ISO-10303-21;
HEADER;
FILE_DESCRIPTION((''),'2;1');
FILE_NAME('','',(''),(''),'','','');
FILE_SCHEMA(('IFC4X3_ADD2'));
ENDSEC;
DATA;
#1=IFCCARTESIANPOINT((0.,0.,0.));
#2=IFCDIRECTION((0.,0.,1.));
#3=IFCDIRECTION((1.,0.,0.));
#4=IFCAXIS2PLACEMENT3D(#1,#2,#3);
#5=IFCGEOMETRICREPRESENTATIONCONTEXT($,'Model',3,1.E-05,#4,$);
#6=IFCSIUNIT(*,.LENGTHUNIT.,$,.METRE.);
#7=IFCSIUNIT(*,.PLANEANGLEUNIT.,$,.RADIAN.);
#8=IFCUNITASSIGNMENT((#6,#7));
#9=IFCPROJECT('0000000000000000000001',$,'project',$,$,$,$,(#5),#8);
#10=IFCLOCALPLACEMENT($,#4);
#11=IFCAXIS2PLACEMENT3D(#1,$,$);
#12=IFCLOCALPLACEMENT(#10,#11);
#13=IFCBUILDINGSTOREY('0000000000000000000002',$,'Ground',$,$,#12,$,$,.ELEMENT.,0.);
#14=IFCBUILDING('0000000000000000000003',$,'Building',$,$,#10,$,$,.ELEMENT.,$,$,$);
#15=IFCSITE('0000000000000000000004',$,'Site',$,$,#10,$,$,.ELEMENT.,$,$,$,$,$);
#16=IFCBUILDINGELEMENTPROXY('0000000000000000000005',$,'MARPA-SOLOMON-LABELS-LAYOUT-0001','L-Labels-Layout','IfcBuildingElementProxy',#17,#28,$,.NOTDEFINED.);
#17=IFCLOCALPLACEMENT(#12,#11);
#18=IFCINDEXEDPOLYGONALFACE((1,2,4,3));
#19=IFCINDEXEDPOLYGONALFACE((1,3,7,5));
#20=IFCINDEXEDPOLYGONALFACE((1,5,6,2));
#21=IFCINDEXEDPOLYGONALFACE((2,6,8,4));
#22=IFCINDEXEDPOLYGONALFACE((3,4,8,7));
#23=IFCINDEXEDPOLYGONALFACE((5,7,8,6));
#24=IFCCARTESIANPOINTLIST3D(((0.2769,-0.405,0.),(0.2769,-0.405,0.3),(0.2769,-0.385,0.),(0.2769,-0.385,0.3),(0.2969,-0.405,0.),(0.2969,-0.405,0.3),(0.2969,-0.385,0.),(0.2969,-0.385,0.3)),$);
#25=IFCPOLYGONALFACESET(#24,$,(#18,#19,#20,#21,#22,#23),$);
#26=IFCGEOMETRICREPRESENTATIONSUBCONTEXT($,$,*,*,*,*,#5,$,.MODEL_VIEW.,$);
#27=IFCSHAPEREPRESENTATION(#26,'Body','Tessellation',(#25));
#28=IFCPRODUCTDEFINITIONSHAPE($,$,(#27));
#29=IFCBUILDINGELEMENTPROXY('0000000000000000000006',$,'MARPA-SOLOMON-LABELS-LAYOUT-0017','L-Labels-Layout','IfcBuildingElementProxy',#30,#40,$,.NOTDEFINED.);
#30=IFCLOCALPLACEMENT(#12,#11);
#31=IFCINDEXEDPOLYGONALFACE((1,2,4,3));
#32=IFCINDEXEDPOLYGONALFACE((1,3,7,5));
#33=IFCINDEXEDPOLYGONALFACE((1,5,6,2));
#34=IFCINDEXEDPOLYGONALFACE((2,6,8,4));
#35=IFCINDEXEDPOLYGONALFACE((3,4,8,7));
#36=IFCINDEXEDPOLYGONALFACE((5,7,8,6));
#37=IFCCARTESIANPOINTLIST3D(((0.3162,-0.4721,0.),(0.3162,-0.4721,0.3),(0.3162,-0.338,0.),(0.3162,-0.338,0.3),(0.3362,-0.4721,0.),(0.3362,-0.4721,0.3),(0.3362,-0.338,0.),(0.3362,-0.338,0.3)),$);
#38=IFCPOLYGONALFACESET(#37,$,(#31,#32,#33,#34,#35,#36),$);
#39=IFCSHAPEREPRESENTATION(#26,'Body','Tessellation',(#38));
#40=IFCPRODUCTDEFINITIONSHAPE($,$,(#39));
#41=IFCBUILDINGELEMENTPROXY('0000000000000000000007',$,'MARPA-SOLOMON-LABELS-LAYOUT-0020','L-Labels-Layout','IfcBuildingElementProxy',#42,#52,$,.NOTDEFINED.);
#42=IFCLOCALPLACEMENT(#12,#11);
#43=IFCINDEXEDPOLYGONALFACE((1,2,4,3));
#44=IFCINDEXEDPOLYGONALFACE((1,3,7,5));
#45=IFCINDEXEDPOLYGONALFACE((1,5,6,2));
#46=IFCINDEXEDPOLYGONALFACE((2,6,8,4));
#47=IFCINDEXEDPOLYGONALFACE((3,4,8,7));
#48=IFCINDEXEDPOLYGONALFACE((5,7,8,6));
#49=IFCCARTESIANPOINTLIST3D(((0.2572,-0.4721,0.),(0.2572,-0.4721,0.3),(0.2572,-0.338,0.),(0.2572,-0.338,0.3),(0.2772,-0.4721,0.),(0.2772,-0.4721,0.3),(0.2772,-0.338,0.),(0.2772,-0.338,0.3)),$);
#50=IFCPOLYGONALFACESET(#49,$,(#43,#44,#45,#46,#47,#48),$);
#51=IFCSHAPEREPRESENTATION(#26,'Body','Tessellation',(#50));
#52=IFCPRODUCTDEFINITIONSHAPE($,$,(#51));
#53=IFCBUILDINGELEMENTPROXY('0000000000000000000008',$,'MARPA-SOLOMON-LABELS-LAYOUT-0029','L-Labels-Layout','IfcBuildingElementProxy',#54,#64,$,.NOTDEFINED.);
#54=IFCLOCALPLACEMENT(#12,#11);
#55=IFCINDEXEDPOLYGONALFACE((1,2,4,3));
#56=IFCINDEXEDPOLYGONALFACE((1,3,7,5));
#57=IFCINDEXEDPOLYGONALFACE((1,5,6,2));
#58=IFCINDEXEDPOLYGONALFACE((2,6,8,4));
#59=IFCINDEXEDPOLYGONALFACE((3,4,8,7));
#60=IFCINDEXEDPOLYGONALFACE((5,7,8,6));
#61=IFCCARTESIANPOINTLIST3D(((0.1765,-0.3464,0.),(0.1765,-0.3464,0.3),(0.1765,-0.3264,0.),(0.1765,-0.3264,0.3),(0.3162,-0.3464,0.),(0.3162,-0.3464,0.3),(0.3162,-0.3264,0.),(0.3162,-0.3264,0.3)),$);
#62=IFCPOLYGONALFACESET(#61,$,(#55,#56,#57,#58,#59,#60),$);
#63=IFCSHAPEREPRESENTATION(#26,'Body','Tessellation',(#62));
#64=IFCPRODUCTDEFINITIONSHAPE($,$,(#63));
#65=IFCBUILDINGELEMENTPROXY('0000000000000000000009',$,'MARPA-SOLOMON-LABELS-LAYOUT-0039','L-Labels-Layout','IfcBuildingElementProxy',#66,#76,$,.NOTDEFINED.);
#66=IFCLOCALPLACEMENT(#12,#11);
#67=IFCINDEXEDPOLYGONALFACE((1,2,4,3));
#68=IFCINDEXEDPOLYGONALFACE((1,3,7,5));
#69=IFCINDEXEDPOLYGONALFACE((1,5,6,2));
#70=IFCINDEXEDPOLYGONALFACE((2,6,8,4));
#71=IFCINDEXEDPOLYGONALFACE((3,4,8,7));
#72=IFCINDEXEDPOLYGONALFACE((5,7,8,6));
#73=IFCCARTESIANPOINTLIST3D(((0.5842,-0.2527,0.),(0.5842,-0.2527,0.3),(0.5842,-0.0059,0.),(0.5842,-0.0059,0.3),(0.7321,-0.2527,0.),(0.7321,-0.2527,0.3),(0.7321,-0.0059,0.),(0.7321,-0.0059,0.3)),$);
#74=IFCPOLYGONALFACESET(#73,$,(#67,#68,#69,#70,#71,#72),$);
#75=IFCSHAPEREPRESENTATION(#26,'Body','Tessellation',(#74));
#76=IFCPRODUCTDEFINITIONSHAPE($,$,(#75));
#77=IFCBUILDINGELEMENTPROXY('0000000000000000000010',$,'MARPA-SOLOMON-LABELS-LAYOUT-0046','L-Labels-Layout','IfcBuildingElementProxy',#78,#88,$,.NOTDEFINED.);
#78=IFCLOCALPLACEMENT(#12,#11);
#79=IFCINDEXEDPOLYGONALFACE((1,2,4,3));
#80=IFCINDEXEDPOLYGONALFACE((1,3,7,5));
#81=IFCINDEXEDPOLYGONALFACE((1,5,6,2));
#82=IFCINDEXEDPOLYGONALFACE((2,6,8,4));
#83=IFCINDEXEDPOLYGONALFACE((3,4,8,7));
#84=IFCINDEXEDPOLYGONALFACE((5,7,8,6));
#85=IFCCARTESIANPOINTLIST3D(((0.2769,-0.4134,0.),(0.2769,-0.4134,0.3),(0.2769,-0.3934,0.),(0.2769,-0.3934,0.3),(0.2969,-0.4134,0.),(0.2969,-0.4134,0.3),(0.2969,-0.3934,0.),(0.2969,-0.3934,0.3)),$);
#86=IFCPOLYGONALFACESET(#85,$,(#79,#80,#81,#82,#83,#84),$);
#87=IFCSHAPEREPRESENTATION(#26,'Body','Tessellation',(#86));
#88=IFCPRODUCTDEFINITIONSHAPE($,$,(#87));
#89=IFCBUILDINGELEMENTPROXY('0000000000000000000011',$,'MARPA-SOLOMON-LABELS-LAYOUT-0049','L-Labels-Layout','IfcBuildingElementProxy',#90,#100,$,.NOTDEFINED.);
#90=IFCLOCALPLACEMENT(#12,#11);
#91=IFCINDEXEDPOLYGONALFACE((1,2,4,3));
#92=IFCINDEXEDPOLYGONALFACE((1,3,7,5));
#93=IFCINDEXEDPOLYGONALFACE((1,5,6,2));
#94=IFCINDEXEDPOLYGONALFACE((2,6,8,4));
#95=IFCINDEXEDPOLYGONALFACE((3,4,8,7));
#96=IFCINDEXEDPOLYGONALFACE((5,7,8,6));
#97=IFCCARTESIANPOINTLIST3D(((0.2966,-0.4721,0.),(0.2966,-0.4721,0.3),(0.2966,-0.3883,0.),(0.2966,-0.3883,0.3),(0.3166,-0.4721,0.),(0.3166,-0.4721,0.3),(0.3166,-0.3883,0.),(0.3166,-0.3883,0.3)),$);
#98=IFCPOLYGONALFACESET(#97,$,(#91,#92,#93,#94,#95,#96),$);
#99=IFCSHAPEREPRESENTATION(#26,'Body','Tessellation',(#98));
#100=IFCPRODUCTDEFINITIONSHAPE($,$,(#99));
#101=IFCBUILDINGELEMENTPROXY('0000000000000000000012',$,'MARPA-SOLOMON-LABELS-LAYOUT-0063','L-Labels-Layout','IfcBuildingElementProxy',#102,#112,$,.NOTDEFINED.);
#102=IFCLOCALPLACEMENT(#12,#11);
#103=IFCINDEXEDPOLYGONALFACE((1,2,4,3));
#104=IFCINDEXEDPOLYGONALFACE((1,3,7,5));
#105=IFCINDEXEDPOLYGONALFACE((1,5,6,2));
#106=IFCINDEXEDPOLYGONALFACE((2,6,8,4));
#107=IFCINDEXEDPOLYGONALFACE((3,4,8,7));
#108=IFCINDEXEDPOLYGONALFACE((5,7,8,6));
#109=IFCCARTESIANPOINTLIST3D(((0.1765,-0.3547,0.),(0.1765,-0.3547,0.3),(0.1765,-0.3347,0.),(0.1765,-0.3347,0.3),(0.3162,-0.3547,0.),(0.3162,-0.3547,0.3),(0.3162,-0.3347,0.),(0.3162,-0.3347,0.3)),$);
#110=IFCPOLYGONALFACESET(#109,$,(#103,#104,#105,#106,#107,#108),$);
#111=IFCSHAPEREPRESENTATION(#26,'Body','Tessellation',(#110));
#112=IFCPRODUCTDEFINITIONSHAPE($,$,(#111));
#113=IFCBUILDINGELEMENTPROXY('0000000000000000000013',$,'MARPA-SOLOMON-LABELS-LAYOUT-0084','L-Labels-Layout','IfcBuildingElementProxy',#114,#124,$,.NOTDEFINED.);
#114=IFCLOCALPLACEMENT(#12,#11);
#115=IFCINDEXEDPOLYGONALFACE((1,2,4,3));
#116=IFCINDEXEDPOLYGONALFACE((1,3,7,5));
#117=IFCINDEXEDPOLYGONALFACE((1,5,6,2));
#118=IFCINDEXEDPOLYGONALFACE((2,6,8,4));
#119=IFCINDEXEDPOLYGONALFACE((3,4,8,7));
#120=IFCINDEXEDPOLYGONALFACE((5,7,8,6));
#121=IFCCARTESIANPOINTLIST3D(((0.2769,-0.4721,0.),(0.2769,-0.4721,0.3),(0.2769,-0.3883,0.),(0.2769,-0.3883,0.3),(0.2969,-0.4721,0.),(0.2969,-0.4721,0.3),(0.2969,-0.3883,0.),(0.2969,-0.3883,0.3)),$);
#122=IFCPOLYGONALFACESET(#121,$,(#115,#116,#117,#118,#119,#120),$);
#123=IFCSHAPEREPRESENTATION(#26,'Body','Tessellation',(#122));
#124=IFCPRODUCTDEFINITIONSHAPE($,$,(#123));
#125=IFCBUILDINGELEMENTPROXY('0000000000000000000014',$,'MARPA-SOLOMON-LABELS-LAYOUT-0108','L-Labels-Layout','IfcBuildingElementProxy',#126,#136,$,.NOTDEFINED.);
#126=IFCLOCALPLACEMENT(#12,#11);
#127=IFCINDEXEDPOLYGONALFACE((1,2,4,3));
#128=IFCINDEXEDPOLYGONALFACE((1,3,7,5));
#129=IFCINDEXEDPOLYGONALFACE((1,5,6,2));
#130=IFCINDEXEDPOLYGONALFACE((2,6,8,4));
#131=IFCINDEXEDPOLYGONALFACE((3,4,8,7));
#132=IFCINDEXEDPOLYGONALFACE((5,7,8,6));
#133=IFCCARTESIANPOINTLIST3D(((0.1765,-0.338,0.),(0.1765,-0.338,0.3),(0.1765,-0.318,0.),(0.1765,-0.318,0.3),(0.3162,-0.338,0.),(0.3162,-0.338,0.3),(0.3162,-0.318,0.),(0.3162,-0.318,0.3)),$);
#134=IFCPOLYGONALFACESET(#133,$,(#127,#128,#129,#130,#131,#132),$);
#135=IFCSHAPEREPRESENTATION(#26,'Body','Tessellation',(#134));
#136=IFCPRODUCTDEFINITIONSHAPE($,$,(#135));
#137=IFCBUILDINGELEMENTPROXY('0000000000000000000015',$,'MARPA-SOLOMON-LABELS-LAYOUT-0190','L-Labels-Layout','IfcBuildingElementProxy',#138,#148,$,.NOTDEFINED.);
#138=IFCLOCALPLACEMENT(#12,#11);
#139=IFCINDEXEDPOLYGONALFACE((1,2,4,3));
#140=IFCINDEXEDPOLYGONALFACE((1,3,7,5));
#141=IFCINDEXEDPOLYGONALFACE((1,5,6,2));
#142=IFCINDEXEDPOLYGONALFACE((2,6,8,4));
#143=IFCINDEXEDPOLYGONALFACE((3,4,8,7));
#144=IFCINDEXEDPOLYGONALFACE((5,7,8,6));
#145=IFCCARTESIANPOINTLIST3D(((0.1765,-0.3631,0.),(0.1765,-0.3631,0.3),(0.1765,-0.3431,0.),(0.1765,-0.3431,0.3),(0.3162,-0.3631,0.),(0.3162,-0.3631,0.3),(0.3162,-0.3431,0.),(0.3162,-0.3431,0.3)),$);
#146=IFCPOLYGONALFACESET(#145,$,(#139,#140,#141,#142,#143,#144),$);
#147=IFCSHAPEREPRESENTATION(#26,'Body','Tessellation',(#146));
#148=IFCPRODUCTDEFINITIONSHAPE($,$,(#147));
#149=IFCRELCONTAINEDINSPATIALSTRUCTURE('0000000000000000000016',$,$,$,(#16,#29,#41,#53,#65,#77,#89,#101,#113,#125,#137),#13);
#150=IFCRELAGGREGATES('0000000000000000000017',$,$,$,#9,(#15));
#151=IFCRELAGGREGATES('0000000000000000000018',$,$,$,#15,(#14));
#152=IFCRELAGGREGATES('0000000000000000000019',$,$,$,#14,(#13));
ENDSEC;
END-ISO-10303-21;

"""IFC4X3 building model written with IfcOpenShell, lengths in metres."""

from ifc_helpers import new_model, si_unit, frame, frame_2d, origin, origin_with_axes, place, context, subcontext, project, spatial, polyline, rectangle, outline, extrude, element, save


model = new_model("IFC4X3")

# Units and contexts
model_context = context("Model", 3, precision=1e-05, world=origin_with_axes())
sub_context = subcontext(model_context, None, None, "MODEL_VIEW")
ifc_project = project(units=[si_unit("LENGTHUNIT", "METRE"), si_unit("PLANEANGLEUNIT", "RADIAN")], contexts=[model_context])

# Site, building, storey
placement = place(None, origin_with_axes())
site = spatial("IfcSite", under=ifc_project, at=placement, Name="Site", CompositionType="ELEMENT")
building = spatial("IfcBuilding", under=site, at=placement, Name="Building", CompositionType="ELEMENT")
storey_placement = place(placement, origin())
storey = spatial("IfcBuildingStorey", under=building, at=storey_placement, Name="Ground", CompositionType="ELEMENT", Elevation=0.0)

# Building element proxies
proxy_1_placement = place(placement, frame((0.2769, -0.405, 0.0)))
element("IfcBuildingElementProxy", 1, at=proxy_1_placement, inside=storey, Name="MARPA-SOLOMON-LABELS-LAYOUT-0001", Description="L-Labels-Layout", ObjectType="IfcBuildingElementProxy", PredefinedType="NOTDEFINED", context=sub_context, shape_type="SweptSolid", body=[
    extrude(rectangle(XDim=0.02, YDim=0.02, at=frame_2d((0.01, 0.01))), origin(), (0.0, 0.0, 1.0), 0.3),
])
for number, where, name in (
    (2, (0.3162, -0.4721, 0.0), "MARPA-SOLOMON-LABELS-LAYOUT-0017"),
    (3, (0.2572, -0.4721, 0.0), "MARPA-SOLOMON-LABELS-LAYOUT-0020"),
):
    element("IfcBuildingElementProxy", number, at=place(placement, frame(where)), inside=storey, Name=name, Description="L-Labels-Layout", ObjectType="IfcBuildingElementProxy", PredefinedType="NOTDEFINED", context=sub_context, shape_type="SweptSolid", body=[
        extrude(rectangle(XDim=0.02, YDim=0.1341, at=frame_2d((0.01, 0.0671))), origin(), (0.0, 0.0, 1.0), 0.3),
    ])
proxy_2_placement = place(placement, frame((0.1765, -0.3464, 0.0)))
element("IfcBuildingElementProxy", 4, at=proxy_2_placement, inside=storey, Name="MARPA-SOLOMON-LABELS-LAYOUT-0029", Description="L-Labels-Layout", ObjectType="IfcBuildingElementProxy", PredefinedType="NOTDEFINED", context=sub_context, shape_type="SweptSolid", body=[
    extrude(rectangle(XDim=0.1397, YDim=0.02, at=frame_2d((0.0699, 0.01))), origin(), (0.0, 0.0, 1.0), 0.3),
])
proxy_3_placement = place(placement, frame((0.5842, -0.2527, 0.0)))
element("IfcBuildingElementProxy", 5, at=proxy_3_placement, inside=storey, Name="MARPA-SOLOMON-LABELS-LAYOUT-0039", Description="L-Labels-Layout", ObjectType="IfcBuildingElementProxy", PredefinedType="NOTDEFINED", context=sub_context, shape_type="SweptSolid", body=[
    extrude(outline(polyline([(0.0, 0.2468), (0.1479, 0.2468), (0.1479, 0.0), (0.0, 0.0), (0.0, 0.2468)])), origin(), (0.0, 0.0, 1.0), 0.3),
])
proxy_4_placement = place(placement, frame((0.2769, -0.4134, 0.0)))
element("IfcBuildingElementProxy", 6, at=proxy_4_placement, inside=storey, Name="MARPA-SOLOMON-LABELS-LAYOUT-0046", Description="L-Labels-Layout", ObjectType="IfcBuildingElementProxy", PredefinedType="NOTDEFINED", context=sub_context, shape_type="SweptSolid", body=[
    extrude(rectangle(XDim=0.02, YDim=0.02, at=frame_2d((0.01, 0.01))), origin(), (0.0, 0.0, 1.0), 0.3),
])
proxy_5_placement = place(placement, frame((0.2966, -0.4721, 0.0)))
element("IfcBuildingElementProxy", 7, at=proxy_5_placement, inside=storey, Name="MARPA-SOLOMON-LABELS-LAYOUT-0049", Description="L-Labels-Layout", ObjectType="IfcBuildingElementProxy", PredefinedType="NOTDEFINED", context=sub_context, shape_type="SweptSolid", body=[
    extrude(rectangle(XDim=0.02, YDim=0.0838, at=frame_2d((0.01, 0.0419))), origin(), (0.0, 0.0, 1.0), 0.3),
])
proxy_6_placement = place(placement, frame((0.1765, -0.3547, 0.0)))
element("IfcBuildingElementProxy", 8, at=proxy_6_placement, inside=storey, Name="MARPA-SOLOMON-LABELS-LAYOUT-0063", Description="L-Labels-Layout", ObjectType="IfcBuildingElementProxy", PredefinedType="NOTDEFINED", context=sub_context, shape_type="SweptSolid", body=[
    extrude(rectangle(XDim=0.1397, YDim=0.02, at=frame_2d((0.0699, 0.01))), origin(), (0.0, 0.0, 1.0), 0.3),
])
for number, where, name in (
    (9, (0.2769, -0.4721, 0.0), "MARPA-SOLOMON-LABELS-LAYOUT-0084"),
):
    element("IfcBuildingElementProxy", number, at=place(placement, frame(where)), inside=storey, Name=name, Description="L-Labels-Layout", ObjectType="IfcBuildingElementProxy", PredefinedType="NOTDEFINED", context=sub_context, shape_type="SweptSolid", body=[
        extrude(rectangle(XDim=0.02, YDim=0.0838, at=frame_2d((0.01, 0.0419))), origin(), (0.0, 0.0, 1.0), 0.3),
    ])
for number, where, name in (
    (10, (0.1765, -0.338, 0.0), "MARPA-SOLOMON-LABELS-LAYOUT-0108"),
):
    element("IfcBuildingElementProxy", number, at=place(placement, frame(where)), inside=storey, Name=name, Description="L-Labels-Layout", ObjectType="IfcBuildingElementProxy", PredefinedType="NOTDEFINED", context=sub_context, shape_type="SweptSolid", body=[
        extrude(rectangle(XDim=0.1397, YDim=0.02, at=frame_2d((0.0699, 0.01))), origin(), (0.0, 0.0, 1.0), 0.3),
    ])
proxy_7_placement = place(placement, frame((0.1765, -0.3631, 0.0)))
element("IfcBuildingElementProxy", 11, at=proxy_7_placement, inside=storey, Name="MARPA-SOLOMON-LABELS-LAYOUT-0190", Description="L-Labels-Layout", ObjectType="IfcBuildingElementProxy", PredefinedType="NOTDEFINED", context=sub_context, shape_type="SweptSolid", body=[
    extrude(rectangle(XDim=0.1397, YDim=0.02, at=frame_2d((0.0699, 0.01))), origin(), (0.0, 0.0, 1.0), 0.3),
])

save(model, "model.ifc")
